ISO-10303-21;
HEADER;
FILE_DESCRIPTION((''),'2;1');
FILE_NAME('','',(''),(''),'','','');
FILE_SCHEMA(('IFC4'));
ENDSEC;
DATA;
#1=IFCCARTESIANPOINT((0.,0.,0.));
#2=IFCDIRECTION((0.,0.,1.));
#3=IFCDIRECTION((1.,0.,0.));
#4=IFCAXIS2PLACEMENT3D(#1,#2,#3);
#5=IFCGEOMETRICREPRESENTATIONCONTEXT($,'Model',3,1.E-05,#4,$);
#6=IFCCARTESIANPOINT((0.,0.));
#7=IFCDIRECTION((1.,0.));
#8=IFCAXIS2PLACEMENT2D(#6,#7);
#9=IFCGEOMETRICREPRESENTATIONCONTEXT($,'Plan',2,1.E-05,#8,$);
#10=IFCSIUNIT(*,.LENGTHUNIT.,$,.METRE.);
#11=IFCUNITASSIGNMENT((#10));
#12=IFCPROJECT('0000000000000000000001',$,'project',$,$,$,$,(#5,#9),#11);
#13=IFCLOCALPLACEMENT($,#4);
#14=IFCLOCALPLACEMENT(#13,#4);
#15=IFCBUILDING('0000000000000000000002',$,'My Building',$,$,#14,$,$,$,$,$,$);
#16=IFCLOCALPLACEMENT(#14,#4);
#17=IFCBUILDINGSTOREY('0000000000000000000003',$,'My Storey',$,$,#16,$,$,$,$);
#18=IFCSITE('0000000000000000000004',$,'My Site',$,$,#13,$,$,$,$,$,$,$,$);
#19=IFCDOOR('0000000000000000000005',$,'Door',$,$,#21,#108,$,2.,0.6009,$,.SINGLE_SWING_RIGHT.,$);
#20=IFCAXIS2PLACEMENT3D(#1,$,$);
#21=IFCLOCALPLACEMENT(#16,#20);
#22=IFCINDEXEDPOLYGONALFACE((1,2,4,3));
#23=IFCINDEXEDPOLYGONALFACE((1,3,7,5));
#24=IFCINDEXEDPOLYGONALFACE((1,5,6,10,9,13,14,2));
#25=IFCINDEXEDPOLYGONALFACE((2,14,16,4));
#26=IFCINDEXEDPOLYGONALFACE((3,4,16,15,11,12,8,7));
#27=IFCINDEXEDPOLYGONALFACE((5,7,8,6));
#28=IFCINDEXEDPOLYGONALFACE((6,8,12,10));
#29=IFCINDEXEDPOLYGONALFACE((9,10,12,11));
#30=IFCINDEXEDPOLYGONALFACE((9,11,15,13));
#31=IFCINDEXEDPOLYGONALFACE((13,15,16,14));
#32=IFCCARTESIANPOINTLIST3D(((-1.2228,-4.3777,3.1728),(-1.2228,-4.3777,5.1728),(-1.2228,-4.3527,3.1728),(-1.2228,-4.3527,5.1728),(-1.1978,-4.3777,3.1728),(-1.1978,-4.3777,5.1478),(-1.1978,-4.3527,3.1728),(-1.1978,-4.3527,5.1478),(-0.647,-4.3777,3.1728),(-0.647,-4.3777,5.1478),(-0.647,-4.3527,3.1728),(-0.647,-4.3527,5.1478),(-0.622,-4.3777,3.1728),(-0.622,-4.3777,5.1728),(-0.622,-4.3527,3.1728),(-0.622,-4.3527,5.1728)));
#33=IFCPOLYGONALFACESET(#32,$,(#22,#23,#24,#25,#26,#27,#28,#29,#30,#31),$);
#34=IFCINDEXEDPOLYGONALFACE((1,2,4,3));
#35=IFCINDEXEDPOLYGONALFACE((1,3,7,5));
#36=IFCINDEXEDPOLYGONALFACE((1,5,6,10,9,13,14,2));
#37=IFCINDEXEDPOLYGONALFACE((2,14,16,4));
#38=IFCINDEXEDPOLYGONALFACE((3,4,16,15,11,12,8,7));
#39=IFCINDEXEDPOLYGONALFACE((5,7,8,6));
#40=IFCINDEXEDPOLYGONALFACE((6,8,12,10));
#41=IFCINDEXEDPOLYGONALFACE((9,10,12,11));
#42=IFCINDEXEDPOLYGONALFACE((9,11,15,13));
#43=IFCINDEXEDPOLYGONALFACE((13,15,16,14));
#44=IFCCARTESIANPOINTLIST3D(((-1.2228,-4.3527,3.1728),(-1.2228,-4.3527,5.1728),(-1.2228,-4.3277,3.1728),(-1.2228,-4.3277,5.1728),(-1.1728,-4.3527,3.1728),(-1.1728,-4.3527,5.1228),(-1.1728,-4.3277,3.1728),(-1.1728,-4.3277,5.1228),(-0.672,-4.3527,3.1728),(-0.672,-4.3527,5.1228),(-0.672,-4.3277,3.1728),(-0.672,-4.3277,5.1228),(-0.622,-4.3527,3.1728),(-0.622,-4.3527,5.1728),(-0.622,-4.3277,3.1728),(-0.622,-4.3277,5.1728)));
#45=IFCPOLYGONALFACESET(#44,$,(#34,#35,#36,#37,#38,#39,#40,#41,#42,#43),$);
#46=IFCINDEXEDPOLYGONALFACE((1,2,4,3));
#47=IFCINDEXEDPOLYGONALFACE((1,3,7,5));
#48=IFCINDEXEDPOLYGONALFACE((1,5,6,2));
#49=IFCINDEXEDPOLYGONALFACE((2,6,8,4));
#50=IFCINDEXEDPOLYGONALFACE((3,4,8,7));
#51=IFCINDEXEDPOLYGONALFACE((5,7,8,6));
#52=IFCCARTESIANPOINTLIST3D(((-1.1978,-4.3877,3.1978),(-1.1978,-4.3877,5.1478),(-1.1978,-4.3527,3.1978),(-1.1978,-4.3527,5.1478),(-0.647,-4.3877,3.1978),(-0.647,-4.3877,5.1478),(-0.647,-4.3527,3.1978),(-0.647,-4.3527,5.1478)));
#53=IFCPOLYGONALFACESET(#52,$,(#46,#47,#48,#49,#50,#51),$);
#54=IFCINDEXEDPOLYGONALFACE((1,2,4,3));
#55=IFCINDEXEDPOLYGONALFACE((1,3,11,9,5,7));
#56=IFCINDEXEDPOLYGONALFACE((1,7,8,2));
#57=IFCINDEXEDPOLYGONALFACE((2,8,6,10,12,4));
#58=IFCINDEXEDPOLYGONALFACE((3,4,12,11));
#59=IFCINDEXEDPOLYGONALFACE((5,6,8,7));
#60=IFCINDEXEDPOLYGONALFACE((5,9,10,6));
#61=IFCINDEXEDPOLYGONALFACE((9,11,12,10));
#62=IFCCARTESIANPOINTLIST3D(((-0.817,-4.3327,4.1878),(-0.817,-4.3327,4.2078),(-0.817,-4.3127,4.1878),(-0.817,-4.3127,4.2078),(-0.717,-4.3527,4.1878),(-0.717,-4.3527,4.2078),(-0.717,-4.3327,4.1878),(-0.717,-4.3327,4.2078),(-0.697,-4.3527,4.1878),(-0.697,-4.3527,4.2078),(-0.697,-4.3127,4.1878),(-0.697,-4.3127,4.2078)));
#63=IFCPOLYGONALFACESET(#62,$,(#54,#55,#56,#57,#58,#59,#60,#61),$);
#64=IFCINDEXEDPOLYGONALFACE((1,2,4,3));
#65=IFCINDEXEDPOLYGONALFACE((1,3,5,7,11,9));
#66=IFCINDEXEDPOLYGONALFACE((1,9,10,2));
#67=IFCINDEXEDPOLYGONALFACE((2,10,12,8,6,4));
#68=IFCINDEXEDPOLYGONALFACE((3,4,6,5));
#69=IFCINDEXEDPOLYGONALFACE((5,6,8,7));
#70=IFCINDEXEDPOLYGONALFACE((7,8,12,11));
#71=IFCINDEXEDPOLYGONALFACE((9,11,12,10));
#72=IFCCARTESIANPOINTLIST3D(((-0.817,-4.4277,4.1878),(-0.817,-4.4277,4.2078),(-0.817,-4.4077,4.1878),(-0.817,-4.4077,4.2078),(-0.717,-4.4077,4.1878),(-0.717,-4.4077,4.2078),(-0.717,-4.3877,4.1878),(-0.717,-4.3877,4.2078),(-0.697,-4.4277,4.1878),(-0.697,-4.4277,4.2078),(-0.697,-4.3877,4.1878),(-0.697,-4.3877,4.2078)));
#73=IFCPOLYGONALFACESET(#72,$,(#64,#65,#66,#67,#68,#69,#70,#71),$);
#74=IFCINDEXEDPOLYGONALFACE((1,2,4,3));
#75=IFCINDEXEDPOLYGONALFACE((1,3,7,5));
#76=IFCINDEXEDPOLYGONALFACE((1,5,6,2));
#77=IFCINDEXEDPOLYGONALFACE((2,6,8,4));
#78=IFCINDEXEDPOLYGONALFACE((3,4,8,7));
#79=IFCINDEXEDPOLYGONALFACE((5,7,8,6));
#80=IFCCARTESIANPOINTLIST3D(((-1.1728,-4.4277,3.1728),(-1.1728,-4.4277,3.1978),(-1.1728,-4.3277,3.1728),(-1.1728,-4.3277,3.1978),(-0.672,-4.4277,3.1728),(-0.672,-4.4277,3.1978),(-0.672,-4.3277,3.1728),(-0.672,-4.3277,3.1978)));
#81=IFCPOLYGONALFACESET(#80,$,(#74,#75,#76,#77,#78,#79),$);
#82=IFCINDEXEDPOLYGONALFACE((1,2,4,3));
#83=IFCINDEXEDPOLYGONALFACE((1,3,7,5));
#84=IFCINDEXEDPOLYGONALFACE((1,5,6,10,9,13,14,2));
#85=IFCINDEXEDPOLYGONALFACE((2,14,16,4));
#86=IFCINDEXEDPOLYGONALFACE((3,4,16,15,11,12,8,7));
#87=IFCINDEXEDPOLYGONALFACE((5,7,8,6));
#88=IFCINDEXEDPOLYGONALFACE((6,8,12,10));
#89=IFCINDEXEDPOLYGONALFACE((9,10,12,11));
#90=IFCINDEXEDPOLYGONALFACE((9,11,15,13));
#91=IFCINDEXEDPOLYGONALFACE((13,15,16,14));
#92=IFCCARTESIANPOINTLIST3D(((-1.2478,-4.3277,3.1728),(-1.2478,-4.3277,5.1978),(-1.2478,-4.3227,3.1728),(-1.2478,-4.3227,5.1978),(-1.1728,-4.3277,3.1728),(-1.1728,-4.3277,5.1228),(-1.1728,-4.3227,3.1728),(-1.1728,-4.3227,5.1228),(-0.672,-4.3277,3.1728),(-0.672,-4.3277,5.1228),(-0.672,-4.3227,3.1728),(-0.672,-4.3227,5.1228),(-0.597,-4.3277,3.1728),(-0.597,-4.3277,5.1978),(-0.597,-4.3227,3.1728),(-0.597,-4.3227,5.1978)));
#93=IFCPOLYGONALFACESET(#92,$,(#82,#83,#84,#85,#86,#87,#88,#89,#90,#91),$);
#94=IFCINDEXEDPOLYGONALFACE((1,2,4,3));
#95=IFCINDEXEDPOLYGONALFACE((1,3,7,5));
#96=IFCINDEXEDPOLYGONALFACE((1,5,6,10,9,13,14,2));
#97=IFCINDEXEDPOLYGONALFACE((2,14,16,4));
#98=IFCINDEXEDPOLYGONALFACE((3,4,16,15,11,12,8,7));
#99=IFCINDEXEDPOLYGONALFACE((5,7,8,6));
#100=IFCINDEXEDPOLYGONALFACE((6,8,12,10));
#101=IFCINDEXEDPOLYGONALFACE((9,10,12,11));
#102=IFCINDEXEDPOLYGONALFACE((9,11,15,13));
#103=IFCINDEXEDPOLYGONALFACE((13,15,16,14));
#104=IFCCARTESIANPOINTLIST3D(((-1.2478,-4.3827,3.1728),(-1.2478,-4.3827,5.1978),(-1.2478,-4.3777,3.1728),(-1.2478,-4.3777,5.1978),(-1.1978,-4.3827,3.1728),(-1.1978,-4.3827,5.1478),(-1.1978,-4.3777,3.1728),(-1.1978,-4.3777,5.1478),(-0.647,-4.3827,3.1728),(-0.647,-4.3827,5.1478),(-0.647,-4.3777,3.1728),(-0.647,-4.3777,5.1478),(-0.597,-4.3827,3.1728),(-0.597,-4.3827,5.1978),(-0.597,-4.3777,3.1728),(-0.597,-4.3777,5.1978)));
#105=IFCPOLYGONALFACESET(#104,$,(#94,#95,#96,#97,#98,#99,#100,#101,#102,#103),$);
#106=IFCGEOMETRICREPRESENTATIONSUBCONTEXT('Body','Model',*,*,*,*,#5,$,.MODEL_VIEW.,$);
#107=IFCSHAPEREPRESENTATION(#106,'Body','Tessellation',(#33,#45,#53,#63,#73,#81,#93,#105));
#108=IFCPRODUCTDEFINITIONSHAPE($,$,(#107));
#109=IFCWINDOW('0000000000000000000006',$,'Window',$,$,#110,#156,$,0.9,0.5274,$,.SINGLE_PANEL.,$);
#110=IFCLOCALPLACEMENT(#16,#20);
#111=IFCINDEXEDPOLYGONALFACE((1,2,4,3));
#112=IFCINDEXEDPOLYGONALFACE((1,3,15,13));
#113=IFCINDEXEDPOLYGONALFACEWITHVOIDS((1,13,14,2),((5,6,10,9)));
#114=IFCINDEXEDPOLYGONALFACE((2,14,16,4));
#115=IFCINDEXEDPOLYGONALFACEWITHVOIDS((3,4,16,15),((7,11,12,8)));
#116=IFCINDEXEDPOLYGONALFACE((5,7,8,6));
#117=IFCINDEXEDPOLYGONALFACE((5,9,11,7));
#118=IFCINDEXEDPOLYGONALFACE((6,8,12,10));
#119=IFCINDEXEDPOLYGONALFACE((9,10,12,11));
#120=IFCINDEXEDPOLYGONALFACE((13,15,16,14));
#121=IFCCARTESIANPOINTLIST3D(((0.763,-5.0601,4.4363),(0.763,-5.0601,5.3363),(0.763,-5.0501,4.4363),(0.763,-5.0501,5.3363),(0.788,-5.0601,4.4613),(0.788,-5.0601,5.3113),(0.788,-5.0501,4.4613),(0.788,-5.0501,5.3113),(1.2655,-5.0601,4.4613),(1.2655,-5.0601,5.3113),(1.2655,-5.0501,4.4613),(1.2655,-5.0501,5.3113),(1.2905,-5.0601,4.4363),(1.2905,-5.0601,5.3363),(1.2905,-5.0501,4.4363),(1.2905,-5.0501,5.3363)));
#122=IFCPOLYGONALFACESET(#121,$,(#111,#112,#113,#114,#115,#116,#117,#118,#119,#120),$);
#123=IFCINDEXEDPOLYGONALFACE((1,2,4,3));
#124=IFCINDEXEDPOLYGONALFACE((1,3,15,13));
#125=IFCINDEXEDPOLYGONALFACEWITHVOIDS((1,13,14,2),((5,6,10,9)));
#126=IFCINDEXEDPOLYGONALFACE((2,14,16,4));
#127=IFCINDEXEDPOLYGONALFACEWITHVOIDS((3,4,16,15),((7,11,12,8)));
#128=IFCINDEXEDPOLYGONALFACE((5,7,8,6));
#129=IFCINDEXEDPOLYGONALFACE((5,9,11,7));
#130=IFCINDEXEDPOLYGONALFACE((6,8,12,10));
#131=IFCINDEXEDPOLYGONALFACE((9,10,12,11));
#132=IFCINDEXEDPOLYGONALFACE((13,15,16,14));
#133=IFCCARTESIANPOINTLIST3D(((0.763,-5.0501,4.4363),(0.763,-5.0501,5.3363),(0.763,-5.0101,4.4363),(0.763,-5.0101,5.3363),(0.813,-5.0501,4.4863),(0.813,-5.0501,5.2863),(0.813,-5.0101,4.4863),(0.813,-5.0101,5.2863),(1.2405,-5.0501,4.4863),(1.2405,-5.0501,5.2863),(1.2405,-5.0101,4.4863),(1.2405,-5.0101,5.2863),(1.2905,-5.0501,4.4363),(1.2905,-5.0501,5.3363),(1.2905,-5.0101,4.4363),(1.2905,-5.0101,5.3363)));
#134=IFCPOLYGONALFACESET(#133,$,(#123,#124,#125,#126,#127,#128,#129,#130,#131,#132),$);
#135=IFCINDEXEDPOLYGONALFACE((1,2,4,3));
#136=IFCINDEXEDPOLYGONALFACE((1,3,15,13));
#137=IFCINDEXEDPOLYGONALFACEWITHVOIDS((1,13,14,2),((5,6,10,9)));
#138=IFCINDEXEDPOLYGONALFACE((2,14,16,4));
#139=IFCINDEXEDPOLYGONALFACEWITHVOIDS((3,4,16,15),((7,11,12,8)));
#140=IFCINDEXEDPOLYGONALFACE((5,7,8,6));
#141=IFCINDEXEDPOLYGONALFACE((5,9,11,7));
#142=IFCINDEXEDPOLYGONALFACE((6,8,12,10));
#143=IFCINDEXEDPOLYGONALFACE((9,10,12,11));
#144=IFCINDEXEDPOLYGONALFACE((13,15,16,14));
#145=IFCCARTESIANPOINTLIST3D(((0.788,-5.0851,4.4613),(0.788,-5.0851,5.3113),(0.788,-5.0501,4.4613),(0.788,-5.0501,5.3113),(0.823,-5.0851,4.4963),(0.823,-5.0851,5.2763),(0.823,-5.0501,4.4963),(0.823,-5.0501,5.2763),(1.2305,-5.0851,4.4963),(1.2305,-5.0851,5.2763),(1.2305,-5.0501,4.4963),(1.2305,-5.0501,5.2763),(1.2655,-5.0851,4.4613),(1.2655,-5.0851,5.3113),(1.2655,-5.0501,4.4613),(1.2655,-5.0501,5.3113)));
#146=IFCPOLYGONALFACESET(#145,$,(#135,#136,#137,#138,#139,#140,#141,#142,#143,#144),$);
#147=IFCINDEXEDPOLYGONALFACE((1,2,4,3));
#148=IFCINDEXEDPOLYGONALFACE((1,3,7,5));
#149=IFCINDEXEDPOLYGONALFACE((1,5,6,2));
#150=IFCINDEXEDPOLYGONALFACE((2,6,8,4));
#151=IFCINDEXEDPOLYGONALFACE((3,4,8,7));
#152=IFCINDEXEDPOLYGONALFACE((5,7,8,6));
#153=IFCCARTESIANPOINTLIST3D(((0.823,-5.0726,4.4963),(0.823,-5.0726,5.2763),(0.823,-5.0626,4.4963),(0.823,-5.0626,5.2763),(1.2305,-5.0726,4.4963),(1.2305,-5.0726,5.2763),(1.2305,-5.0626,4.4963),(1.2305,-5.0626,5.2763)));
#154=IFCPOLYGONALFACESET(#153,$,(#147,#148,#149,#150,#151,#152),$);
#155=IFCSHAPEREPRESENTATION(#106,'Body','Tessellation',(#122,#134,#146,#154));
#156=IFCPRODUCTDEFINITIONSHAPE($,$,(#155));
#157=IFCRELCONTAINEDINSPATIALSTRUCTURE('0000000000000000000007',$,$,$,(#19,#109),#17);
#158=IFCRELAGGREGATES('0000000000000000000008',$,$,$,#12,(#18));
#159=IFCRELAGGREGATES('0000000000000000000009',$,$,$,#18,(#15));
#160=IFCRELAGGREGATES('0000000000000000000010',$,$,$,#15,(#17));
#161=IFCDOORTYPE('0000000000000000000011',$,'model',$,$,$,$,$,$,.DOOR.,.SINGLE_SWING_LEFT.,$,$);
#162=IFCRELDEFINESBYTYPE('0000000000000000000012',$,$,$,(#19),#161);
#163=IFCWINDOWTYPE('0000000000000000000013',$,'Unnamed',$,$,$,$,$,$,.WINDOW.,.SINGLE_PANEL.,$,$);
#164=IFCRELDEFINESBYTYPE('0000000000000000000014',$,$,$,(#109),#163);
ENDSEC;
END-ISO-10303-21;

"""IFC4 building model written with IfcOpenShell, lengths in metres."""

from ifc_helpers import new_model, entity, si_unit, frame, origin_with_axes, origin_2d_with_axis, place, context, subcontext, project, spatial, line, indexed_curve, outline, extrude, shape, source, transform, mapped, type_object, type_shapes, element, save


model = new_model("IFC4")

# Units and contexts
model_context = context("Model", 3, precision=1e-05, world=origin_with_axes())
plan_context = context("Plan", 2, precision=1e-05, world=origin_2d_with_axis())
body_context_1 = subcontext(model_context, "Body", "Model", "MODEL_VIEW")
body_context_2 = subcontext(plan_context, "Body", "Plan", "PLAN_VIEW")
ifc_project = project(units=[si_unit("LENGTHUNIT", "METRE")], contexts=[model_context, plan_context])

# Site, building, storey
site_placement = place(None, origin_with_axes())
site = spatial("IfcSite", under=ifc_project, at=site_placement, Name="My Site")
building_placement = place(site_placement, origin_with_axes())
building = spatial("IfcBuilding", under=site, at=building_placement, Name="My Building")
storey_placement = place(building_placement, origin_with_axes())
storey = spatial("IfcBuildingStorey", under=building, at=storey_placement, Name="My Storey")

# Shared definitions
window_type_1 = type_object("IfcWindowType", Name="Unnamed", PartitioningType="SINGLE_PANEL", PredefinedType="WINDOW")
shared_shape_1 = source(origin_with_axes(), body_context_1, "Body", "SweptSolid", [
    extrude(outline(indexed_curve([(0.0, 0.0), (0.5274, 0.0), (0.5274, 0.9), (0.0, 0.9)], segments=[line(1, 2, 3, 4, 1)]), holes=[indexed_curve([(0.025, 0.025), (0.5024, 0.025), (0.5024, 0.875), (0.025, 0.875)], segments=[line(1, 2, 3, 4, 1)])]), frame((0.0, 0.09, 0.0), z_axis=(0.0, -1.0, 0.0), x_axis=(1.0, 0.0, 0.0)), (0.0, 0.0, -1.0), 0.01),
    extrude(outline(indexed_curve([(0.0, 0.0), (0.5274, 0.0), (0.5274, 0.9), (0.0, 0.9)], segments=[line(1, 2, 3, 4, 1)]), holes=[indexed_curve([(0.05, 0.05), (0.4774, 0.05), (0.4774, 0.85), (0.05, 0.85)], segments=[line(1, 2, 3, 4, 1)])]), frame((0.0, 0.05, 0.0), z_axis=(0.0, -1.0, 0.0), x_axis=(1.0, 0.0, 0.0)), (0.0, 0.0, -1.0), 0.04),
    extrude(outline(indexed_curve([(0.0, 0.0), (0.4774, 0.0), (0.4774, 0.85), (0.0, 0.85)], segments=[line(1, 2, 3, 4, 1)]), holes=[indexed_curve([(0.035, 0.035), (0.4424, 0.035), (0.4424, 0.815), (0.035, 0.815)], segments=[line(1, 2, 3, 4, 1)])]), frame((0.025, 0.09, 0.025), z_axis=(0.0, -1.0, 0.0), x_axis=(1.0, 0.0, 0.0)), (0.0, 0.0, -1.0), 0.035),
    extrude(outline(indexed_curve([(0.035, 0.035), (0.4424, 0.035), (0.4424, 0.815), (0.035, 0.815)], segments=[line(1, 2, 3, 4, 1)])), frame((0.025, 0.1025, 0.025), z_axis=(0.0, -1.0, 0.0), x_axis=(1.0, 0.0, 0.0)), (0.0, 0.0, -1.0), 0.01),
])
shared_shape_2 = source(origin_with_axes(), body_context_2, "Body", "Curve2D", [
    entity("IfcIndexedPolyCurve", entity("IfcCartesianPointList2D", [[0.05, 0.05], [0.4774, 0.05]])),
    entity("IfcIndexedPolyCurve", entity("IfcCartesianPointList2D", [[0.0, 0.1], [0.025, 0.1], [0.025, 0.09], [0.05, 0.09], [0.05, 0.05], [0.0, 0.05]]), [entity("IfcLineIndex", [1, 2, 3, 4, 5, 6, 1])]),
    entity("IfcIndexedPolyCurve", entity("IfcCartesianPointList2D", [[0.5274, 0.1], [0.5024, 0.1], [0.5024, 0.09], [0.4774, 0.09], [0.4774, 0.05], [0.5274, 0.05]]), [entity("IfcLineIndex", [1, 2, 3, 4, 5, 6, 1])]),
    entity("IfcIndexedPolyCurve", entity("IfcCartesianPointList2D", [[0.025, 0.09], [0.06, 0.09], [0.06, 0.125], [0.025, 0.125]]), [entity("IfcLineIndex", [1, 2, 3, 4, 1])]),
    entity("IfcIndexedPolyCurve", entity("IfcCartesianPointList2D", [[0.5024, 0.09], [0.4674, 0.09], [0.4674, 0.125], [0.5024, 0.125]]), [entity("IfcLineIndex", [1, 2, 3, 4, 1])]),
    entity("IfcIndexedPolyCurve", entity("IfcCartesianPointList2D", [[0.06, 0.09], [0.4674, 0.09]])),
    entity("IfcIndexedPolyCurve", entity("IfcCartesianPointList2D", [[0.06, 0.125], [0.4674, 0.125]])),
    entity("IfcIndexedPolyCurve", entity("IfcCartesianPointList2D", [[0.06, 0.1075], [0.4674, 0.1075]])),
])
type_shapes(window_type_1, [shared_shape_1, shared_shape_2])

# Door
door_type_1 = type_object("IfcDoorType", Name="model", OperationType="SINGLE_SWING_LEFT", PredefinedType="DOOR")
shared_shape_3 = source(origin_with_axes(), body_context_1, "Body", "SweptSolid", [
    extrude(outline(indexed_curve([(0.0, 0.0), (0.0, 2.0), (0.6009, 2.0), (0.6009, 0.0), (0.5759, 0.0), (0.5759, 1.975), (0.025, 1.975), (0.025, 0.0)], segments=[line(1, 2, 3, 4, 5, 6, 7, 8, 1)])), frame((0.0, 0.025, 0.0), z_axis=(0.0, -1.0, 0.0), x_axis=(1.0, 0.0, 0.0)), (0.0, 0.0, -1.0), 0.025),
    extrude(outline(indexed_curve([(0.0, 0.0), (0.0, 2.0), (0.6009, 2.0), (0.6009, 0.0), (0.5509, 0.0), (0.5509, 1.95), (0.05, 1.95), (0.05, 0.0)], segments=[line(1, 2, 3, 4, 5, 6, 7, 8, 1)])), frame((0.0, 0.0, 0.0), z_axis=(0.0, -1.0, 0.0), x_axis=(1.0, 0.0, 0.0)), (0.0, 0.0, -1.0), 0.025),
    extrude(outline(indexed_curve([(0.0, 0.0), (0.5509, 0.0), (0.5509, 0.035), (0.0, 0.035)], segments=[line(1, 2, 3, 4, 1)])), frame((0.025, 0.025, 0.025), z_axis=(0.0, 0.0, 1.0), x_axis=(1.0, 0.0, 0.0)), (0.0, 0.0, 1.0), 1.95),
    extrude(outline(indexed_curve([(0.0, 0.0), (0.0, -0.04), (0.12, -0.04), (0.12, -0.02), (0.02, -0.02), (0.02, 0.0)], segments=[line(1, 2, 3, 4, 5, 6, 1)])), frame((0.075, 0.025, 1.015), z_axis=(0.0, 0.0, 1.0), x_axis=(1.0, 0.0, 0.0)), (0.0, 0.0, 1.0), 0.02),
    extrude(outline(indexed_curve([(0.0, 0.0), (0.0, 0.04), (0.12, 0.04), (0.12, 0.02), (0.02, 0.02), (0.02, 0.0)], segments=[line(1, 2, 3, 4, 5, 6, 1)])), frame((0.075, 0.06, 1.015), z_axis=(0.0, 0.0, 1.0), x_axis=(1.0, 0.0, 0.0)), (0.0, 0.0, 1.0), 0.02),
    extrude(outline(indexed_curve([(0.0, 0.0), (0.5009, 0.0), (0.5009, 0.1), (0.0, 0.1)], segments=[line(1, 2, 3, 4, 1)])), frame((0.05, 0.0, 0.0), z_axis=(0.0, 0.0, 1.0), x_axis=(1.0, 0.0, 0.0)), (0.0, 0.0, 1.0), 0.025),
    extrude(outline(indexed_curve([(0.0, 0.0), (0.0, 2.025), (0.6509, 2.025), (0.6509, 0.0), (0.5759, 0.0), (0.5759, 1.95), (0.075, 1.95), (0.075, 0.0)], segments=[line(1, 2, 3, 4, 5, 6, 7, 8, 1)])), frame((-0.025, -0.005, 0.0), z_axis=(0.0, -1.0, 0.0), x_axis=(1.0, 0.0, 0.0)), (0.0, 0.0, -1.0), 0.005),
    extrude(outline(indexed_curve([(0.0, 0.0), (0.0, 2.025), (0.6509, 2.025), (0.6509, 0.0), (0.6009, 0.0), (0.6009, 1.975), (0.05, 1.975), (0.05, 0.0)], segments=[line(1, 2, 3, 4, 5, 6, 7, 8, 1)])), frame((-0.025, 0.05, 0.0), z_axis=(0.0, -1.0, 0.0), x_axis=(1.0, 0.0, 0.0)), (0.0, 0.0, -1.0), 0.005),
])
shared_shape_4 = source(origin_with_axes(), body_context_2, "Body", "Curve2D", [
    entity("IfcIndexedPolyCurve", entity("IfcCartesianPointList2D", [[0.0, 0.0], [0.0, 0.05], [0.025, 0.05], [0.025, 0.025], [0.05, 0.025], [0.05, 0.0]]), [entity("IfcLineIndex", [1, 2, 3, 4, 5, 6, 1])]),
    entity("IfcIndexedPolyCurve", entity("IfcCartesianPointList2D", [[0.6009, 0.0], [0.6009, 0.05], [0.5759, 0.05], [0.5759, 0.025], [0.5509, 0.025], [0.5509, 0.0]]), [entity("IfcLineIndex", [1, 2, 3, 4, 5, 6, 1])]),
    entity("IfcTrimmedCurve", entity("IfcEllipse", entity("IfcAxis2Placement2D", entity("IfcCartesianPoint", [0.5409, 0.05]), entity("IfcDirection", [1.0, 0.0])), 0.5159, 0.5509), [entity("IfcCartesianPoint", [0.5409, 0.6009])], [entity("IfcCartesianPoint", [0.025, 0.05])], True, "CARTESIAN"),
    entity("IfcIndexedPolyCurve", entity("IfcCartesianPointList2D", [[0.5759, 0.05], [0.5409, 0.05], [0.5409, 0.6009], [0.5759, 0.6009]]), [entity("IfcLineIndex", [1, 2, 3, 4, 1])]),
])
type_shapes(door_type_1, [shared_shape_3, shared_shape_4])
door_1_placement = place(storey_placement, frame((-0.622, -4.3277, 3.1728), z_axis=(0.0, 0.0, 1.0), x_axis=(-1.0, 0.0, 0.0)))
element("IfcDoor", 1, at=door_1_placement, inside=storey, type_object=door_type_1, Name="Door", OperationType="SINGLE_SWING_RIGHT", OverallHeight=2.0, OverallWidth=0.6009, shapes=[
    shape(body_context_1, "Body", "MappedRepresentation", [mapped(shared_shape_3, transform((0.0, 0.0, 0.0), x_axis=(1.0, 0.0, 0.0), y_axis=(0.0, 1.0, 0.0), z_axis=(0.0, 0.0, 1.0), scale=1.0))]),
    shape(body_context_2, "Body", "MappedRepresentation", [mapped(shared_shape_4, transform((0.0, 0.0, 0.0), x_axis=(1.0, 0.0, 0.0), y_axis=(0.0, 1.0, 0.0), z_axis=(0.0, 0.0, 1.0), scale=1.0))]),
])

# Window
for number, where, z_axis, x_axis, name in (
    (2, (1.2905, -4.9601, 4.4363), (0.0, 0.0, 1.0), (-1.0, 0.0, 0.0), "Window"),
):
    element("IfcWindow", number, at=place(storey_placement, frame(where, z_axis=z_axis, x_axis=x_axis)), inside=storey, type_object=window_type_1, Name=name, OverallHeight=0.9, OverallWidth=0.5274, PartitioningType="SINGLE_PANEL", shapes=[
        shape(body_context_1, "Body", "MappedRepresentation", [mapped(shared_shape_1, transform((0.0, 0.0, 0.0), x_axis=(1.0, 0.0, 0.0), y_axis=(0.0, 1.0, 0.0), z_axis=(0.0, 0.0, 1.0), scale=1.0))]),
        shape(body_context_2, "Body", "MappedRepresentation", [mapped(shared_shape_2, transform((0.0, 0.0, 0.0), x_axis=(1.0, 0.0, 0.0), y_axis=(0.0, 1.0, 0.0), z_axis=(0.0, 0.0, 1.0), scale=1.0))]),
    ])

save(model, "model.ifc")
